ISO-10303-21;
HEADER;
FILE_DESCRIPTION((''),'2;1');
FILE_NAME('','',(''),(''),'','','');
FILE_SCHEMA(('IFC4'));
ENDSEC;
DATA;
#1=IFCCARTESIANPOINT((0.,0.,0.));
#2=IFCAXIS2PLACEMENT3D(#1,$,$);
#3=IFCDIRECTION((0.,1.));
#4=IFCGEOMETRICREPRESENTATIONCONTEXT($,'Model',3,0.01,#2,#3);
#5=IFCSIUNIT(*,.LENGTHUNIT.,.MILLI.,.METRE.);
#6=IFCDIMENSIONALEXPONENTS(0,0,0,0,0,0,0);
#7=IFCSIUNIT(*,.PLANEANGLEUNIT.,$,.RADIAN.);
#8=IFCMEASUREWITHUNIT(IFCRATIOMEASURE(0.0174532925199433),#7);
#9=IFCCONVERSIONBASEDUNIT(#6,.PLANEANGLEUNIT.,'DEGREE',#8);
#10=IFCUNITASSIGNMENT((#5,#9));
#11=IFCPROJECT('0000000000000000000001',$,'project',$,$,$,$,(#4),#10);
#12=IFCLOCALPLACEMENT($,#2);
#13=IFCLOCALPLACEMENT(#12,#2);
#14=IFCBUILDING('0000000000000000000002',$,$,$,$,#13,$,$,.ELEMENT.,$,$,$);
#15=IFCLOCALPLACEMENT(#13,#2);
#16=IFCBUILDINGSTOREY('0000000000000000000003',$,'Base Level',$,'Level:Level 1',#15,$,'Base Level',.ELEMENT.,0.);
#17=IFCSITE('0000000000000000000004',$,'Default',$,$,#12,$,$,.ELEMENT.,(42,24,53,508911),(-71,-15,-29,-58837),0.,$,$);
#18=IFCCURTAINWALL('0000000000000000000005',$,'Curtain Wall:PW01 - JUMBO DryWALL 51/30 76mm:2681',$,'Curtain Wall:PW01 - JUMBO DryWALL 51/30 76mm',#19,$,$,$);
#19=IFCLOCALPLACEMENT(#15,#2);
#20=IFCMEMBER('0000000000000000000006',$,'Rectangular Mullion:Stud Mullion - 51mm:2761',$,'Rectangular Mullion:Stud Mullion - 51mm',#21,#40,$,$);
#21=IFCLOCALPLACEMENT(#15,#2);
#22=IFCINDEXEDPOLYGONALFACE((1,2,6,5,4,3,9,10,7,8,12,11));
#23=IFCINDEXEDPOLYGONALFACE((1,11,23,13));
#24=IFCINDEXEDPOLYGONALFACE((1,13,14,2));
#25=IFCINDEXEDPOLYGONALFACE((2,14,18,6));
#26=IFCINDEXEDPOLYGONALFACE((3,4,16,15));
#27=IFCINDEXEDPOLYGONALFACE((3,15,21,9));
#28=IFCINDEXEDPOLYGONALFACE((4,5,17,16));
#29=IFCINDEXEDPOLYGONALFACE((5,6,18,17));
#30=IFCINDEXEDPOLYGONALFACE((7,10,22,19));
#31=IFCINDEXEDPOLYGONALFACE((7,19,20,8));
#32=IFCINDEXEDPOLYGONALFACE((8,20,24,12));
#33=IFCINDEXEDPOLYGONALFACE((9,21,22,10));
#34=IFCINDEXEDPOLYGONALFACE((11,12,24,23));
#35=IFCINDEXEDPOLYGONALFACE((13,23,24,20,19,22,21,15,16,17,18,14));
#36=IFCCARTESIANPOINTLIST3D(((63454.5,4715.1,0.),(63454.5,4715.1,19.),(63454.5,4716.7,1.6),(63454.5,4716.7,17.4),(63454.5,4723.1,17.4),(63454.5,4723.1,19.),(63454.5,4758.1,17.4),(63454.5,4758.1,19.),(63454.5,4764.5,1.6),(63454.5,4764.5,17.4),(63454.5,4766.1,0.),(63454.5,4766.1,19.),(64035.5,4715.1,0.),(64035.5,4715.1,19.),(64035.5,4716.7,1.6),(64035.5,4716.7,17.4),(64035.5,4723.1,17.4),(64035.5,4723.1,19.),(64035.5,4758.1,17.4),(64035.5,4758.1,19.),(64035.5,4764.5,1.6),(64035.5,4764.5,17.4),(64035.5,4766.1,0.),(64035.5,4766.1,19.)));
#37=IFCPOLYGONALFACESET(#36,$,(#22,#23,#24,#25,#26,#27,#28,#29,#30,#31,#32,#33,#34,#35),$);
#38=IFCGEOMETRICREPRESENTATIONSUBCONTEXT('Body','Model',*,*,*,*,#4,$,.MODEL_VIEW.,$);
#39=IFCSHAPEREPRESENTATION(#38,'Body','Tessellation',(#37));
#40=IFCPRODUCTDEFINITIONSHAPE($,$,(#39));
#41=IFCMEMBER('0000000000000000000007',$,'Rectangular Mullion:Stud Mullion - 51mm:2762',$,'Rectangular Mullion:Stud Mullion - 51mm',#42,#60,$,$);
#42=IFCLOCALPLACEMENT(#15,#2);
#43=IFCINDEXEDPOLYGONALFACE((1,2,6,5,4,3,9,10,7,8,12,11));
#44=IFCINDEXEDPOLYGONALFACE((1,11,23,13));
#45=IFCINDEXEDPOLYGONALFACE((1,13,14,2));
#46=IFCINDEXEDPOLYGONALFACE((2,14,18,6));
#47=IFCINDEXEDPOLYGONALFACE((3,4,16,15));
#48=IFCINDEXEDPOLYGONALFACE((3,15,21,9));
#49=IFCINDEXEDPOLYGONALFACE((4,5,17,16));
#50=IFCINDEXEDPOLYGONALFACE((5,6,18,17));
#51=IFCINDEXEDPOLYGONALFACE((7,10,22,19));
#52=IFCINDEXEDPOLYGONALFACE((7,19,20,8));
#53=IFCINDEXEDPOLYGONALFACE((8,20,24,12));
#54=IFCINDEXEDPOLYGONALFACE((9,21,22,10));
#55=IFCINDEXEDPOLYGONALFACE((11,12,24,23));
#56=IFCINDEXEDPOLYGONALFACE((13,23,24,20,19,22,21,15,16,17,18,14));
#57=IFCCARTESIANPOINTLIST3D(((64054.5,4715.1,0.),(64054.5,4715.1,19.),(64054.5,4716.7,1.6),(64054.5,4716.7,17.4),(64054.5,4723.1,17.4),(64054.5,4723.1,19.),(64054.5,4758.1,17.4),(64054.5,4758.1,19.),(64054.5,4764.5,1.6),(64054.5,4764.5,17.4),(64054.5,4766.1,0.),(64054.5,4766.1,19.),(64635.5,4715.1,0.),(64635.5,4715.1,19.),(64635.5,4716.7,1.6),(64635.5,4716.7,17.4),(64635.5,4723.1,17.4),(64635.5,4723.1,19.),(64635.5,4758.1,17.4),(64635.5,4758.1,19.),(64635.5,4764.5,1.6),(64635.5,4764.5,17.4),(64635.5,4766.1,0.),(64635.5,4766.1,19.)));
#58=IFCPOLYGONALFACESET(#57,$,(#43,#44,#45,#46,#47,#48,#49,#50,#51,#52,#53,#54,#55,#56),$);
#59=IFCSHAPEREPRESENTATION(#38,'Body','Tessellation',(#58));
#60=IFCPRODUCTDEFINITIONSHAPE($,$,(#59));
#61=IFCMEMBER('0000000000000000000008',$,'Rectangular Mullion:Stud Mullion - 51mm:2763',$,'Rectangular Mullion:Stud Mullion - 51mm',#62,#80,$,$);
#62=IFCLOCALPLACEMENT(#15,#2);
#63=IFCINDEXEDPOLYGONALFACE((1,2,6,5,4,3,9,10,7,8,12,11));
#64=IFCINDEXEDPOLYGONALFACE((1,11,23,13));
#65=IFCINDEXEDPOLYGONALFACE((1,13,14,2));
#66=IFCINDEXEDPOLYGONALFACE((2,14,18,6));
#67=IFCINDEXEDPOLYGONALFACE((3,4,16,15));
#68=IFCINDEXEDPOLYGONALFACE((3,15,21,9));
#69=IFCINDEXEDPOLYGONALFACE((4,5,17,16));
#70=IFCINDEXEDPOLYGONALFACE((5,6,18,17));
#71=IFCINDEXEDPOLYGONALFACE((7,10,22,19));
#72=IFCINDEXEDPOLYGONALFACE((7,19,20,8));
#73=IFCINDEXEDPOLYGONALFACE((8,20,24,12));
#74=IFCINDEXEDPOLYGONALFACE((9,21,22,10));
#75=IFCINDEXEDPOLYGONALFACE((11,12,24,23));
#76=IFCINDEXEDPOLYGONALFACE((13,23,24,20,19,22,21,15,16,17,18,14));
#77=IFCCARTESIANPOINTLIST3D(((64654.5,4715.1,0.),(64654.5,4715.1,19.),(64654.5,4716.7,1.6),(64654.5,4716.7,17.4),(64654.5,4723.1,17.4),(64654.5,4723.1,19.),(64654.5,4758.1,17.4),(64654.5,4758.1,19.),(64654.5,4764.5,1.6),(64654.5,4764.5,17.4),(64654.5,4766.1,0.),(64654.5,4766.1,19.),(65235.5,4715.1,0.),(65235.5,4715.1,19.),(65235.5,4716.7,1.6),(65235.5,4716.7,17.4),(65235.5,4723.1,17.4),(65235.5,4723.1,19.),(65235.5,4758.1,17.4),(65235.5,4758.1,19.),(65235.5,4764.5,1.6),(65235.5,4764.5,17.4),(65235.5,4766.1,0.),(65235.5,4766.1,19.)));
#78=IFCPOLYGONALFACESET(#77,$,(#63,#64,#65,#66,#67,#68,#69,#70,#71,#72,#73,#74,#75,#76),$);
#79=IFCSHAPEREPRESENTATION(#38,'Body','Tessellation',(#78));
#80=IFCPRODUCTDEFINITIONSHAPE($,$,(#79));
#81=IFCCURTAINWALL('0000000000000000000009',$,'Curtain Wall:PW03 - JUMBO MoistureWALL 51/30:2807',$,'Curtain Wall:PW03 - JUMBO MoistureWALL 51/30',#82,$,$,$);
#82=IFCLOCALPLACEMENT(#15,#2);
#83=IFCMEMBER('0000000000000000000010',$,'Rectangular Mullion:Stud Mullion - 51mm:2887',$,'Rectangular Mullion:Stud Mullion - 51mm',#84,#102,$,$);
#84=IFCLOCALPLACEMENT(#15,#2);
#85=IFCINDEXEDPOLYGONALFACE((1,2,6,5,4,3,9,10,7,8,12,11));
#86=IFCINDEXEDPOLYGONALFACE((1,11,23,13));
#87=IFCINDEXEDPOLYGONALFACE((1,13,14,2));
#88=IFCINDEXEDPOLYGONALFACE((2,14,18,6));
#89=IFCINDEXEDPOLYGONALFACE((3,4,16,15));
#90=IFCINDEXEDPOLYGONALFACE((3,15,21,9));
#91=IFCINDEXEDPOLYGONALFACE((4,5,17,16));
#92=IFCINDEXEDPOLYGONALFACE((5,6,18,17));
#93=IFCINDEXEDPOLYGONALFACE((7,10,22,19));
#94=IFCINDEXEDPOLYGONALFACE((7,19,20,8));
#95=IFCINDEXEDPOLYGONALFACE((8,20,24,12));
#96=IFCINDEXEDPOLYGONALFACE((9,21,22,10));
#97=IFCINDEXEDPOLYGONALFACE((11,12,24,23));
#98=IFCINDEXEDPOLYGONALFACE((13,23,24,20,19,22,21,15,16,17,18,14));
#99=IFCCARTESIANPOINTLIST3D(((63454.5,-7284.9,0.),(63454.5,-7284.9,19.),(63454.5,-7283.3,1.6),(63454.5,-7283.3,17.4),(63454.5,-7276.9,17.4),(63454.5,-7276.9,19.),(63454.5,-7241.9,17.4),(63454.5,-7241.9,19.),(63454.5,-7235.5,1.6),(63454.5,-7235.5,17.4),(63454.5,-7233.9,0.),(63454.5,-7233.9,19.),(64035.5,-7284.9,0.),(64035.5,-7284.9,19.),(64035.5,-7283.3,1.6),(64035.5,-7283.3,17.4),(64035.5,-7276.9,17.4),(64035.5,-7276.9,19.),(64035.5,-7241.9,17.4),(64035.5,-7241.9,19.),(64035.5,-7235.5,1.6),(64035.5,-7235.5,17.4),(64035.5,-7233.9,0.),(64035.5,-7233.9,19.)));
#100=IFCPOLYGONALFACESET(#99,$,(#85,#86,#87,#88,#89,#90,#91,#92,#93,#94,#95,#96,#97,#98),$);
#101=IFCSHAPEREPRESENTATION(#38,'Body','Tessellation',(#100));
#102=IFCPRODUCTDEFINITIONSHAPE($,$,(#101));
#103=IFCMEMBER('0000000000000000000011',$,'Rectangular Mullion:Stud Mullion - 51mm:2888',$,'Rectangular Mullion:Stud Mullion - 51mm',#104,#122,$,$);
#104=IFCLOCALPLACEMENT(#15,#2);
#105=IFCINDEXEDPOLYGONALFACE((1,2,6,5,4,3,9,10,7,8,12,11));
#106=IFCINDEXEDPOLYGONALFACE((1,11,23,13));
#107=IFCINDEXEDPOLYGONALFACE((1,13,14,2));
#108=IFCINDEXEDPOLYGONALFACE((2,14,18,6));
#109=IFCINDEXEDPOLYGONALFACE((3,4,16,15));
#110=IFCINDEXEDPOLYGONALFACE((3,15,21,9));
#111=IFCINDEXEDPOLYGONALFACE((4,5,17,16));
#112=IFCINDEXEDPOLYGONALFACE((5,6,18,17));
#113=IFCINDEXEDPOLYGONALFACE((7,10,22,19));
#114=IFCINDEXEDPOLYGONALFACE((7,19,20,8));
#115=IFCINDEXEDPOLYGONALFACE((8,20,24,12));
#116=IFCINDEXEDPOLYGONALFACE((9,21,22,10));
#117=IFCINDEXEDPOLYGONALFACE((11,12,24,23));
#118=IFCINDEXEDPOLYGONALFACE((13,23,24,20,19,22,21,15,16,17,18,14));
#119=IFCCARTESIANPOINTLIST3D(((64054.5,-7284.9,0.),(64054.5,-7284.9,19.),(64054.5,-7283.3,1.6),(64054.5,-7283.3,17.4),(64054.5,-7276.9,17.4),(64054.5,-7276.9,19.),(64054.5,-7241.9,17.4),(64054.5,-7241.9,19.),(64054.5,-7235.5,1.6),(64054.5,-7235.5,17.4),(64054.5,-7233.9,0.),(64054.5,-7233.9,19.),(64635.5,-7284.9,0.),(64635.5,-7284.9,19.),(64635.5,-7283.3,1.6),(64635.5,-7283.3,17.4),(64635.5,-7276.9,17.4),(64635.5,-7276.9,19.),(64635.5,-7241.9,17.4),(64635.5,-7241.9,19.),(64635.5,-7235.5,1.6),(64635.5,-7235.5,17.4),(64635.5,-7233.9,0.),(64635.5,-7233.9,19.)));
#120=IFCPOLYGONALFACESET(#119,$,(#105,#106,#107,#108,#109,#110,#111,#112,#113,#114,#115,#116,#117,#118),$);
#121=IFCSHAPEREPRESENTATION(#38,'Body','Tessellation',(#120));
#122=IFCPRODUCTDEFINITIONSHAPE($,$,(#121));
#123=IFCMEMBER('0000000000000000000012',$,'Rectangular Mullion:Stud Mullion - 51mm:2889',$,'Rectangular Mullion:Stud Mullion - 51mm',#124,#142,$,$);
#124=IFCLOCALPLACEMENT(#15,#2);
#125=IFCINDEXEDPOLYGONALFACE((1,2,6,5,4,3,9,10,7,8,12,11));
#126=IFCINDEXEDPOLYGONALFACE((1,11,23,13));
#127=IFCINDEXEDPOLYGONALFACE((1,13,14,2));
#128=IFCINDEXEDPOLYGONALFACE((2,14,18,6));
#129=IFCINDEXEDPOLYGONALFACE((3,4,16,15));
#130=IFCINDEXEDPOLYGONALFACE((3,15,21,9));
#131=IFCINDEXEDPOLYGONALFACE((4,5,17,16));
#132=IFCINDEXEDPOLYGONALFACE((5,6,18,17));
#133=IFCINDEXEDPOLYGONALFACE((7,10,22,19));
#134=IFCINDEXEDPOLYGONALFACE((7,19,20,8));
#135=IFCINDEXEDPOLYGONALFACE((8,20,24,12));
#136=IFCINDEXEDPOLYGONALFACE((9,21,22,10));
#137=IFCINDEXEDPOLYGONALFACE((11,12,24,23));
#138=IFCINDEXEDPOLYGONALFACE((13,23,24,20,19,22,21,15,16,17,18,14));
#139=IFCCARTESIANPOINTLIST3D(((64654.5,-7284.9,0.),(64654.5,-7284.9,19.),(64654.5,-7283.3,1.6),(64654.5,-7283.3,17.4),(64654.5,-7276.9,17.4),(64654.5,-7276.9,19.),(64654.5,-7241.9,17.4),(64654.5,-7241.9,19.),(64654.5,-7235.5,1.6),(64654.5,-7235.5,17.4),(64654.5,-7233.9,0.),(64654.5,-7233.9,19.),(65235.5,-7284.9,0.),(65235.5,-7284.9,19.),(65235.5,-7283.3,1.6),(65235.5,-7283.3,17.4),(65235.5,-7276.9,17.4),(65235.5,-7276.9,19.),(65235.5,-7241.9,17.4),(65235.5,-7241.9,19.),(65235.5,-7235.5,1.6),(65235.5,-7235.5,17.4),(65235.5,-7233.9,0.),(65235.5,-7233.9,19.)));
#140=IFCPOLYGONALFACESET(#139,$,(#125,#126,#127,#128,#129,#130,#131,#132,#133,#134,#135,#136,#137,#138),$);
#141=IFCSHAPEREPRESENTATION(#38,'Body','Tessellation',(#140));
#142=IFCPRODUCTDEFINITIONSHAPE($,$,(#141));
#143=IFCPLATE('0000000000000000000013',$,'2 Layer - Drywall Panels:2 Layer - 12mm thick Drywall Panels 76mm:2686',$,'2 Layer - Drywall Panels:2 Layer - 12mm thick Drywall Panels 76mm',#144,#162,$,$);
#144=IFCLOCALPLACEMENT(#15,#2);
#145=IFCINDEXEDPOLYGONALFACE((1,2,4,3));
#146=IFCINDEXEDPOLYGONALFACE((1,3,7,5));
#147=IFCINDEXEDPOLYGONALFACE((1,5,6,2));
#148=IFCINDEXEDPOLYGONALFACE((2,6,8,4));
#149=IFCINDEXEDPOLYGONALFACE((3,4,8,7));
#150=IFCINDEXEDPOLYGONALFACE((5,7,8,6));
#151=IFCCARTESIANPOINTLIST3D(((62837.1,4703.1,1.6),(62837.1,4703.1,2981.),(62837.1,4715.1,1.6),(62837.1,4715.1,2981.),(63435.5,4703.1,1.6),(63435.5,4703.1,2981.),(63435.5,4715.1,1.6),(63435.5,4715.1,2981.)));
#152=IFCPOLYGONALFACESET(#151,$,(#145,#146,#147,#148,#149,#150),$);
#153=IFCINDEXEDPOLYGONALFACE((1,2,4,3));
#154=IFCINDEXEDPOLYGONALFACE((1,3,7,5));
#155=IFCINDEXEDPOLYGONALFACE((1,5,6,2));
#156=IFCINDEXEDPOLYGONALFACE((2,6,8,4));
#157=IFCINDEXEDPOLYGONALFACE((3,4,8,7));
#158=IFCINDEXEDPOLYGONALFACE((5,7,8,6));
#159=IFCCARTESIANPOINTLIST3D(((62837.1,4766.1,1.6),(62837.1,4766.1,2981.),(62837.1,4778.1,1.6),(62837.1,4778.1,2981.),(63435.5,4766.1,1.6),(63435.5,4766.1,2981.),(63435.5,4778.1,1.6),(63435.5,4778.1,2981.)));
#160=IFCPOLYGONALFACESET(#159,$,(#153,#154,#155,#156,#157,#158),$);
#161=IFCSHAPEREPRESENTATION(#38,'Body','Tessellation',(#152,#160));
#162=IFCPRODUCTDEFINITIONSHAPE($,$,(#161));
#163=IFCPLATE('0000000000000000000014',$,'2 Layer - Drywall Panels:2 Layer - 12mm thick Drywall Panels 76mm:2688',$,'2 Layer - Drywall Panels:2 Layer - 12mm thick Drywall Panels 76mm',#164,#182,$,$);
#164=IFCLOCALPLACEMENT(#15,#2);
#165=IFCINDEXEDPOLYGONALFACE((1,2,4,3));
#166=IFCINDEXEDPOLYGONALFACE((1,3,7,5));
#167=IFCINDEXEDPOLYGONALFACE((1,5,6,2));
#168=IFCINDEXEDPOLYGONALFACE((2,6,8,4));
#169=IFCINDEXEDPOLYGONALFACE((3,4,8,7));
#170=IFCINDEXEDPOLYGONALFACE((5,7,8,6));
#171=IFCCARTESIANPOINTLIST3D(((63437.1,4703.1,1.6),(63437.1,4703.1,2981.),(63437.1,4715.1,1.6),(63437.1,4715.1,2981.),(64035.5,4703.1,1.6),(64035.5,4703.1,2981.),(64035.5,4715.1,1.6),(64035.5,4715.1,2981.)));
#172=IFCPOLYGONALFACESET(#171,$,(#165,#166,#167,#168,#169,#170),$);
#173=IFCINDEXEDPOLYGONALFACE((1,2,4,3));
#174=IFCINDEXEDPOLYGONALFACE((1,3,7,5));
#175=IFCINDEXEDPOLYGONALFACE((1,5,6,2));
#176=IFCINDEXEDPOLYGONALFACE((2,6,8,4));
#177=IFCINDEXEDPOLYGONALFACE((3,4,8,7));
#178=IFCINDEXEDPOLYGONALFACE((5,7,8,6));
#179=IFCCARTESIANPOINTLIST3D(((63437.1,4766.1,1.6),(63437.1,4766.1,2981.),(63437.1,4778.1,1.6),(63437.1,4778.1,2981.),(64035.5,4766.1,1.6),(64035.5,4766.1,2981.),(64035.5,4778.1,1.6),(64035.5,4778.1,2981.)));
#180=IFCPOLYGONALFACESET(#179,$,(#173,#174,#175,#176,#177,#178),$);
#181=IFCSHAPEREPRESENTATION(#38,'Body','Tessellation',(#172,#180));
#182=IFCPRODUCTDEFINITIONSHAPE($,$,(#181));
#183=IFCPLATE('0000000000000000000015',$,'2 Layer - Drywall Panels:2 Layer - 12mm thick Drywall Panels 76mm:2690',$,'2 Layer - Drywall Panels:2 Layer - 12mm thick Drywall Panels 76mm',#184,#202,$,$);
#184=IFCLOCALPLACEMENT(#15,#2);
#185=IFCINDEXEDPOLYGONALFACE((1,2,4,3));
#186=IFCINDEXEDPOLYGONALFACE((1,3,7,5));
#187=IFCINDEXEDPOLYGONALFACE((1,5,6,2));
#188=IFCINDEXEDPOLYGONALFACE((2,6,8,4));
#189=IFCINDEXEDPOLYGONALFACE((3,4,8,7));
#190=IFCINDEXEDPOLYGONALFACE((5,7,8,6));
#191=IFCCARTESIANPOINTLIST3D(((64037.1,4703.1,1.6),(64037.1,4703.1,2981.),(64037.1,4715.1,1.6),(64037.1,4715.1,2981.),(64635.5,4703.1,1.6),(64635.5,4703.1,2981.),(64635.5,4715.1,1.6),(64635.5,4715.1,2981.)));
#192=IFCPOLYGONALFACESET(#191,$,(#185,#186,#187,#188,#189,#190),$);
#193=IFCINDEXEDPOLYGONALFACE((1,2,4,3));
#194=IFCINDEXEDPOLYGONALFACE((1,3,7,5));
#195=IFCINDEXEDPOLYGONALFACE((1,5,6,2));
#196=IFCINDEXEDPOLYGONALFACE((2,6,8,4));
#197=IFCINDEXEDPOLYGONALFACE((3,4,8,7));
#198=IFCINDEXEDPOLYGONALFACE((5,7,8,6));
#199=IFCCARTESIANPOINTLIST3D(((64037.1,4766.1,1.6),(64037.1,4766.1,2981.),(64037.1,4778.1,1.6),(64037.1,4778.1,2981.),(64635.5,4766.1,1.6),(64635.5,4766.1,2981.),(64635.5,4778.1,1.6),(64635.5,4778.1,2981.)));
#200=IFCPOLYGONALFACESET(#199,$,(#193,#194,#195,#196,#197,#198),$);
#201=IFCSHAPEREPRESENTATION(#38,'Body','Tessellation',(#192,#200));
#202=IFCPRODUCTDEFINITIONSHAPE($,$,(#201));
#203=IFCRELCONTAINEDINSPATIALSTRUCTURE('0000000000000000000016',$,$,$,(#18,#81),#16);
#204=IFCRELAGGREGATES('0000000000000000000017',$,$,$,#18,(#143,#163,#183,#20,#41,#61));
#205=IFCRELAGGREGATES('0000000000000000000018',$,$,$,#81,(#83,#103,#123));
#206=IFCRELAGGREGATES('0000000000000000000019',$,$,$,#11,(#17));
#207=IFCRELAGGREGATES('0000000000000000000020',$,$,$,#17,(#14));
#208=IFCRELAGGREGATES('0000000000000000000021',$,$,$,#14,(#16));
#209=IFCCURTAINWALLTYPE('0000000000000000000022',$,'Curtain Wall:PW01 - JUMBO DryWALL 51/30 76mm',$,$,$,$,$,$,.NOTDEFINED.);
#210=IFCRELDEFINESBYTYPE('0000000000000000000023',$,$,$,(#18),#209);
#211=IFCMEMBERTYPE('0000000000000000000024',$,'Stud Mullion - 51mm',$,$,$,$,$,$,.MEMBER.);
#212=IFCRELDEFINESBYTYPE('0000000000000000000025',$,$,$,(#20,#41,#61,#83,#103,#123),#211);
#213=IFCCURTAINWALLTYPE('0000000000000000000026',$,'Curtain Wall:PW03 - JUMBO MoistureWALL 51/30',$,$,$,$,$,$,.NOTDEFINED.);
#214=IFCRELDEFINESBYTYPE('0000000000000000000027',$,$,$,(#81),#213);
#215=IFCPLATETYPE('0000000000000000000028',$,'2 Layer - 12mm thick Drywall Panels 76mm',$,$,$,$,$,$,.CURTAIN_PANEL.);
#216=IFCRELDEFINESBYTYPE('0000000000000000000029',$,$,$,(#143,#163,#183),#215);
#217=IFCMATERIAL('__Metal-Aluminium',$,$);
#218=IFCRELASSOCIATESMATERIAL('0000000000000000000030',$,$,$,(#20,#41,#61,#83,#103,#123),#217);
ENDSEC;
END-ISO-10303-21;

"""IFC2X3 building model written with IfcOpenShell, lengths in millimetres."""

from ifc_helpers import new_model, entity, si_unit, converted_unit, direction, frame, frame_2d, origin, origin_2d_with_axis, place, context, subcontext, project, spatial, polyline, rectangle, outline, extrude, source, transform, mapped, material, type_object, type_shapes, element, aggregate, save


model = new_model("IFC2X3")

# Units and contexts
model_context = context("Model", 3, precision=0.01, world=origin(), true_north=direction((0.0, 1.0)))
body_context = subcontext(model_context, "Body", "Model", "MODEL_VIEW")
ifc_project = project(units=[si_unit("LENGTHUNIT", "METRE", prefix="MILLI"), converted_unit("PLANEANGLEUNIT", "DEGREE", entity("IfcRatioMeasure", 0.0174532925199433), si_unit("PLANEANGLEUNIT", "RADIAN"), dimensions=[0, 0, 0, 0, 0, 0, 0])], contexts=[model_context])

# Site, building, storey
site_placement = place(None, origin())
site = spatial("IfcSite", under=ifc_project, at=site_placement, Name="Default", CompositionType="ELEMENT", RefLatitude=(42, 24, 53, 508911), RefLongitude=(-71, -15, -29, -58837), RefElevation=0.0)
building_placement = place(site_placement, origin())
building = spatial("IfcBuilding", under=site, at=building_placement, CompositionType="ELEMENT")
storey_placement = place(building_placement, origin())
storey = spatial("IfcBuildingStorey", under=building, at=storey_placement, Name="Base Level", ObjectType="Level:Level 1", LongName="Base Level", CompositionType="ELEMENT", Elevation=0.0)

# Curtain walls, members
curtain_wall_type_1 = type_object("IfcCurtainWallType", Name="Curtain Wall:PW01 - JUMBO DryWALL 51/30 76mm", PredefinedType="NOTDEFINED")
curtain_wall_1_placement = place(building_placement, origin())
curtain_wall_1 = element("IfcCurtainWall", 1, at=curtain_wall_1_placement, inside=storey, type_object=curtain_wall_type_1, Name="Curtain Wall:PW01 - JUMBO DryWALL 51/30 76mm:2681", ObjectType="Curtain Wall:PW01 - JUMBO DryWALL 51/30 76mm")
ifc_material = material(Name="__Metal-Aluminium")
member_type_1 = type_object("IfcMemberType", Name="Stud Mullion - 51mm", PredefinedType="MEMBER")
shared_shape_1 = source(origin(), body_context, "Body", "SweptSolid", [
    extrude(outline(polyline([(17.5, -6.6), (25.5, -6.6), (25.5, 12.4), (-25.5, 12.4), (-25.5, -6.6), (-17.5, -6.6), (-17.5, -5.0), (-23.9, -5.0), (-23.9, 10.8), (23.9, 10.8), (23.9, -5.0), (17.5, -5.0), (17.5, -6.6)])), frame((-12.4, 0.0, -581.0), z_axis=(0.0, 0.0, 1.0), x_axis=(0.0, -1.0, 0.0)), (0.0, 0.0, 1.0), 581.0),
])
type_shapes(member_type_1, [shared_shape_1])
member_1_placement = place(building_placement, frame((63454.5, 4740.6, 0.0), z_axis=(-1.0, 0.0, 0.0), x_axis=(0.0, 0.0, -1.0)))
member_1 = element("IfcMember", 2, at=member_1_placement, type_object=member_type_1, material=ifc_material, Name="Rectangular Mullion:Stud Mullion - 51mm:2761", ObjectType="Rectangular Mullion:Stud Mullion - 51mm", context=body_context, shape_type="MappedRepresentation", body=[
    mapped(shared_shape_1, transform((0.0, 0.0, 0.0), scale=1.0)),
])
member_2_placement = place(building_placement, frame((64054.5, 4740.6, 0.0), z_axis=(-1.0, 0.0, 0.0), x_axis=(0.0, 0.0, -1.0)))
member_2 = element("IfcMember", 3, at=member_2_placement, type_object=member_type_1, material=ifc_material, Name="Rectangular Mullion:Stud Mullion - 51mm:2762", ObjectType="Rectangular Mullion:Stud Mullion - 51mm", context=body_context, shape_type="MappedRepresentation", body=[
    mapped(shared_shape_1, transform((0.0, 0.0, 0.0), scale=1.0)),
])
member_3_placement = place(building_placement, frame((64654.5, 4740.6, 0.0), z_axis=(-1.0, 0.0, 0.0), x_axis=(0.0, 0.0, -1.0)))
member_3 = element("IfcMember", 4, at=member_3_placement, type_object=member_type_1, material=ifc_material, Name="Rectangular Mullion:Stud Mullion - 51mm:2763", ObjectType="Rectangular Mullion:Stud Mullion - 51mm", context=body_context, shape_type="MappedRepresentation", body=[
    mapped(shared_shape_1, transform((0.0, 0.0, 0.0), scale=1.0)),
])
curtain_wall_type_2 = type_object("IfcCurtainWallType", Name="Curtain Wall:PW03 - JUMBO MoistureWALL 51/30", PredefinedType="NOTDEFINED")
curtain_wall_2_placement = place(building_placement, origin())
curtain_wall_2 = element("IfcCurtainWall", 5, at=curtain_wall_2_placement, inside=storey, type_object=curtain_wall_type_2, Name="Curtain Wall:PW03 - JUMBO MoistureWALL 51/30:2807", ObjectType="Curtain Wall:PW03 - JUMBO MoistureWALL 51/30")
member_4_placement = place(building_placement, frame((63454.5, -7259.4, 0.0), z_axis=(-1.0, 0.0, 0.0), x_axis=(0.0, 0.0, -1.0)))
member_4 = element("IfcMember", 6, at=member_4_placement, type_object=member_type_1, material=ifc_material, Name="Rectangular Mullion:Stud Mullion - 51mm:2887", ObjectType="Rectangular Mullion:Stud Mullion - 51mm", context=body_context, shape_type="MappedRepresentation", body=[
    mapped(shared_shape_1, transform((0.0, 0.0, 0.0), scale=1.0)),
])
member_5_placement = place(building_placement, frame((64054.5, -7259.4, 0.0), z_axis=(-1.0, 0.0, 0.0), x_axis=(0.0, 0.0, -1.0)))
member_5 = element("IfcMember", 7, at=member_5_placement, type_object=member_type_1, material=ifc_material, Name="Rectangular Mullion:Stud Mullion - 51mm:2888", ObjectType="Rectangular Mullion:Stud Mullion - 51mm", context=body_context, shape_type="MappedRepresentation", body=[
    mapped(shared_shape_1, transform((0.0, 0.0, 0.0), scale=1.0)),
])
member_6_placement = place(building_placement, frame((64654.5, -7259.4, 0.0), z_axis=(-1.0, 0.0, 0.0), x_axis=(0.0, 0.0, -1.0)))
member_6 = element("IfcMember", 8, at=member_6_placement, type_object=member_type_1, material=ifc_material, Name="Rectangular Mullion:Stud Mullion - 51mm:2889", ObjectType="Rectangular Mullion:Stud Mullion - 51mm", context=body_context, shape_type="MappedRepresentation", body=[
    mapped(shared_shape_1, transform((0.0, 0.0, 0.0), scale=1.0)),
])

# Plates
plate_type = type_object("IfcPlateType", Name="2 Layer - 12mm thick Drywall Panels 76mm", PredefinedType="CURTAIN_PANEL")
shared_shape_2 = source(origin(), body_context, "Body", "SweptSolid", [
    extrude(rectangle(XDim=598.4, YDim=12.0, at=origin_2d_with_axis()), frame((0.0, -31.5, 0.0), z_axis=(0.0, 0.0, 1.0), x_axis=(-1.0, 0.0, 0.0)), (0.0, 0.0, 1.0), 2979.4),
    extrude(rectangle(XDim=12.0, YDim=598.4, at=frame_2d((0.0, 0.0), x_axis=(1.0, 0.0))), frame((0.0, 31.5, 0.0), z_axis=(0.0, 0.0, 1.0), x_axis=(0.0, 1.0, 0.0)), (0.0, 0.0, 1.0), 2979.4),
])
type_shapes(plate_type, [shared_shape_2])
plate_1_placement = place(curtain_wall_1_placement, frame((63136.3, 4740.6, 1.6)))
plate_1 = element("IfcPlate", 9, at=plate_1_placement, type_object=plate_type, Name="2 Layer - Drywall Panels:2 Layer - 12mm thick Drywall Panels 76mm:2686", ObjectType="2 Layer - Drywall Panels:2 Layer - 12mm thick Drywall Panels 76mm", context=body_context, shape_type="MappedRepresentation", body=[
    mapped(shared_shape_2, transform((0.0, 0.0, 0.0), scale=1.0)),
])
plate_2_placement = place(curtain_wall_1_placement, frame((63736.3, 4740.6, 1.6)))
plate_2 = element("IfcPlate", 10, at=plate_2_placement, type_object=plate_type, Name="2 Layer - Drywall Panels:2 Layer - 12mm thick Drywall Panels 76mm:2688", ObjectType="2 Layer - Drywall Panels:2 Layer - 12mm thick Drywall Panels 76mm", context=body_context, shape_type="MappedRepresentation", body=[
    mapped(shared_shape_2, transform((0.0, 0.0, 0.0), scale=1.0)),
])
plate_3_placement = place(curtain_wall_1_placement, frame((64336.3, 4740.6, 1.6)))
plate_3 = element("IfcPlate", 11, at=plate_3_placement, type_object=plate_type, Name="2 Layer - Drywall Panels:2 Layer - 12mm thick Drywall Panels 76mm:2690", ObjectType="2 Layer - Drywall Panels:2 Layer - 12mm thick Drywall Panels 76mm", context=body_context, shape_type="MappedRepresentation", body=[
    mapped(shared_shape_2, transform((0.0, 0.0, 0.0), scale=1.0)),
])
aggregate(curtain_wall_1, [plate_1, plate_2, plate_3, member_1, member_2, member_3])
aggregate(curtain_wall_2, [member_4, member_5, member_6])

save(model, "model.ifc")
